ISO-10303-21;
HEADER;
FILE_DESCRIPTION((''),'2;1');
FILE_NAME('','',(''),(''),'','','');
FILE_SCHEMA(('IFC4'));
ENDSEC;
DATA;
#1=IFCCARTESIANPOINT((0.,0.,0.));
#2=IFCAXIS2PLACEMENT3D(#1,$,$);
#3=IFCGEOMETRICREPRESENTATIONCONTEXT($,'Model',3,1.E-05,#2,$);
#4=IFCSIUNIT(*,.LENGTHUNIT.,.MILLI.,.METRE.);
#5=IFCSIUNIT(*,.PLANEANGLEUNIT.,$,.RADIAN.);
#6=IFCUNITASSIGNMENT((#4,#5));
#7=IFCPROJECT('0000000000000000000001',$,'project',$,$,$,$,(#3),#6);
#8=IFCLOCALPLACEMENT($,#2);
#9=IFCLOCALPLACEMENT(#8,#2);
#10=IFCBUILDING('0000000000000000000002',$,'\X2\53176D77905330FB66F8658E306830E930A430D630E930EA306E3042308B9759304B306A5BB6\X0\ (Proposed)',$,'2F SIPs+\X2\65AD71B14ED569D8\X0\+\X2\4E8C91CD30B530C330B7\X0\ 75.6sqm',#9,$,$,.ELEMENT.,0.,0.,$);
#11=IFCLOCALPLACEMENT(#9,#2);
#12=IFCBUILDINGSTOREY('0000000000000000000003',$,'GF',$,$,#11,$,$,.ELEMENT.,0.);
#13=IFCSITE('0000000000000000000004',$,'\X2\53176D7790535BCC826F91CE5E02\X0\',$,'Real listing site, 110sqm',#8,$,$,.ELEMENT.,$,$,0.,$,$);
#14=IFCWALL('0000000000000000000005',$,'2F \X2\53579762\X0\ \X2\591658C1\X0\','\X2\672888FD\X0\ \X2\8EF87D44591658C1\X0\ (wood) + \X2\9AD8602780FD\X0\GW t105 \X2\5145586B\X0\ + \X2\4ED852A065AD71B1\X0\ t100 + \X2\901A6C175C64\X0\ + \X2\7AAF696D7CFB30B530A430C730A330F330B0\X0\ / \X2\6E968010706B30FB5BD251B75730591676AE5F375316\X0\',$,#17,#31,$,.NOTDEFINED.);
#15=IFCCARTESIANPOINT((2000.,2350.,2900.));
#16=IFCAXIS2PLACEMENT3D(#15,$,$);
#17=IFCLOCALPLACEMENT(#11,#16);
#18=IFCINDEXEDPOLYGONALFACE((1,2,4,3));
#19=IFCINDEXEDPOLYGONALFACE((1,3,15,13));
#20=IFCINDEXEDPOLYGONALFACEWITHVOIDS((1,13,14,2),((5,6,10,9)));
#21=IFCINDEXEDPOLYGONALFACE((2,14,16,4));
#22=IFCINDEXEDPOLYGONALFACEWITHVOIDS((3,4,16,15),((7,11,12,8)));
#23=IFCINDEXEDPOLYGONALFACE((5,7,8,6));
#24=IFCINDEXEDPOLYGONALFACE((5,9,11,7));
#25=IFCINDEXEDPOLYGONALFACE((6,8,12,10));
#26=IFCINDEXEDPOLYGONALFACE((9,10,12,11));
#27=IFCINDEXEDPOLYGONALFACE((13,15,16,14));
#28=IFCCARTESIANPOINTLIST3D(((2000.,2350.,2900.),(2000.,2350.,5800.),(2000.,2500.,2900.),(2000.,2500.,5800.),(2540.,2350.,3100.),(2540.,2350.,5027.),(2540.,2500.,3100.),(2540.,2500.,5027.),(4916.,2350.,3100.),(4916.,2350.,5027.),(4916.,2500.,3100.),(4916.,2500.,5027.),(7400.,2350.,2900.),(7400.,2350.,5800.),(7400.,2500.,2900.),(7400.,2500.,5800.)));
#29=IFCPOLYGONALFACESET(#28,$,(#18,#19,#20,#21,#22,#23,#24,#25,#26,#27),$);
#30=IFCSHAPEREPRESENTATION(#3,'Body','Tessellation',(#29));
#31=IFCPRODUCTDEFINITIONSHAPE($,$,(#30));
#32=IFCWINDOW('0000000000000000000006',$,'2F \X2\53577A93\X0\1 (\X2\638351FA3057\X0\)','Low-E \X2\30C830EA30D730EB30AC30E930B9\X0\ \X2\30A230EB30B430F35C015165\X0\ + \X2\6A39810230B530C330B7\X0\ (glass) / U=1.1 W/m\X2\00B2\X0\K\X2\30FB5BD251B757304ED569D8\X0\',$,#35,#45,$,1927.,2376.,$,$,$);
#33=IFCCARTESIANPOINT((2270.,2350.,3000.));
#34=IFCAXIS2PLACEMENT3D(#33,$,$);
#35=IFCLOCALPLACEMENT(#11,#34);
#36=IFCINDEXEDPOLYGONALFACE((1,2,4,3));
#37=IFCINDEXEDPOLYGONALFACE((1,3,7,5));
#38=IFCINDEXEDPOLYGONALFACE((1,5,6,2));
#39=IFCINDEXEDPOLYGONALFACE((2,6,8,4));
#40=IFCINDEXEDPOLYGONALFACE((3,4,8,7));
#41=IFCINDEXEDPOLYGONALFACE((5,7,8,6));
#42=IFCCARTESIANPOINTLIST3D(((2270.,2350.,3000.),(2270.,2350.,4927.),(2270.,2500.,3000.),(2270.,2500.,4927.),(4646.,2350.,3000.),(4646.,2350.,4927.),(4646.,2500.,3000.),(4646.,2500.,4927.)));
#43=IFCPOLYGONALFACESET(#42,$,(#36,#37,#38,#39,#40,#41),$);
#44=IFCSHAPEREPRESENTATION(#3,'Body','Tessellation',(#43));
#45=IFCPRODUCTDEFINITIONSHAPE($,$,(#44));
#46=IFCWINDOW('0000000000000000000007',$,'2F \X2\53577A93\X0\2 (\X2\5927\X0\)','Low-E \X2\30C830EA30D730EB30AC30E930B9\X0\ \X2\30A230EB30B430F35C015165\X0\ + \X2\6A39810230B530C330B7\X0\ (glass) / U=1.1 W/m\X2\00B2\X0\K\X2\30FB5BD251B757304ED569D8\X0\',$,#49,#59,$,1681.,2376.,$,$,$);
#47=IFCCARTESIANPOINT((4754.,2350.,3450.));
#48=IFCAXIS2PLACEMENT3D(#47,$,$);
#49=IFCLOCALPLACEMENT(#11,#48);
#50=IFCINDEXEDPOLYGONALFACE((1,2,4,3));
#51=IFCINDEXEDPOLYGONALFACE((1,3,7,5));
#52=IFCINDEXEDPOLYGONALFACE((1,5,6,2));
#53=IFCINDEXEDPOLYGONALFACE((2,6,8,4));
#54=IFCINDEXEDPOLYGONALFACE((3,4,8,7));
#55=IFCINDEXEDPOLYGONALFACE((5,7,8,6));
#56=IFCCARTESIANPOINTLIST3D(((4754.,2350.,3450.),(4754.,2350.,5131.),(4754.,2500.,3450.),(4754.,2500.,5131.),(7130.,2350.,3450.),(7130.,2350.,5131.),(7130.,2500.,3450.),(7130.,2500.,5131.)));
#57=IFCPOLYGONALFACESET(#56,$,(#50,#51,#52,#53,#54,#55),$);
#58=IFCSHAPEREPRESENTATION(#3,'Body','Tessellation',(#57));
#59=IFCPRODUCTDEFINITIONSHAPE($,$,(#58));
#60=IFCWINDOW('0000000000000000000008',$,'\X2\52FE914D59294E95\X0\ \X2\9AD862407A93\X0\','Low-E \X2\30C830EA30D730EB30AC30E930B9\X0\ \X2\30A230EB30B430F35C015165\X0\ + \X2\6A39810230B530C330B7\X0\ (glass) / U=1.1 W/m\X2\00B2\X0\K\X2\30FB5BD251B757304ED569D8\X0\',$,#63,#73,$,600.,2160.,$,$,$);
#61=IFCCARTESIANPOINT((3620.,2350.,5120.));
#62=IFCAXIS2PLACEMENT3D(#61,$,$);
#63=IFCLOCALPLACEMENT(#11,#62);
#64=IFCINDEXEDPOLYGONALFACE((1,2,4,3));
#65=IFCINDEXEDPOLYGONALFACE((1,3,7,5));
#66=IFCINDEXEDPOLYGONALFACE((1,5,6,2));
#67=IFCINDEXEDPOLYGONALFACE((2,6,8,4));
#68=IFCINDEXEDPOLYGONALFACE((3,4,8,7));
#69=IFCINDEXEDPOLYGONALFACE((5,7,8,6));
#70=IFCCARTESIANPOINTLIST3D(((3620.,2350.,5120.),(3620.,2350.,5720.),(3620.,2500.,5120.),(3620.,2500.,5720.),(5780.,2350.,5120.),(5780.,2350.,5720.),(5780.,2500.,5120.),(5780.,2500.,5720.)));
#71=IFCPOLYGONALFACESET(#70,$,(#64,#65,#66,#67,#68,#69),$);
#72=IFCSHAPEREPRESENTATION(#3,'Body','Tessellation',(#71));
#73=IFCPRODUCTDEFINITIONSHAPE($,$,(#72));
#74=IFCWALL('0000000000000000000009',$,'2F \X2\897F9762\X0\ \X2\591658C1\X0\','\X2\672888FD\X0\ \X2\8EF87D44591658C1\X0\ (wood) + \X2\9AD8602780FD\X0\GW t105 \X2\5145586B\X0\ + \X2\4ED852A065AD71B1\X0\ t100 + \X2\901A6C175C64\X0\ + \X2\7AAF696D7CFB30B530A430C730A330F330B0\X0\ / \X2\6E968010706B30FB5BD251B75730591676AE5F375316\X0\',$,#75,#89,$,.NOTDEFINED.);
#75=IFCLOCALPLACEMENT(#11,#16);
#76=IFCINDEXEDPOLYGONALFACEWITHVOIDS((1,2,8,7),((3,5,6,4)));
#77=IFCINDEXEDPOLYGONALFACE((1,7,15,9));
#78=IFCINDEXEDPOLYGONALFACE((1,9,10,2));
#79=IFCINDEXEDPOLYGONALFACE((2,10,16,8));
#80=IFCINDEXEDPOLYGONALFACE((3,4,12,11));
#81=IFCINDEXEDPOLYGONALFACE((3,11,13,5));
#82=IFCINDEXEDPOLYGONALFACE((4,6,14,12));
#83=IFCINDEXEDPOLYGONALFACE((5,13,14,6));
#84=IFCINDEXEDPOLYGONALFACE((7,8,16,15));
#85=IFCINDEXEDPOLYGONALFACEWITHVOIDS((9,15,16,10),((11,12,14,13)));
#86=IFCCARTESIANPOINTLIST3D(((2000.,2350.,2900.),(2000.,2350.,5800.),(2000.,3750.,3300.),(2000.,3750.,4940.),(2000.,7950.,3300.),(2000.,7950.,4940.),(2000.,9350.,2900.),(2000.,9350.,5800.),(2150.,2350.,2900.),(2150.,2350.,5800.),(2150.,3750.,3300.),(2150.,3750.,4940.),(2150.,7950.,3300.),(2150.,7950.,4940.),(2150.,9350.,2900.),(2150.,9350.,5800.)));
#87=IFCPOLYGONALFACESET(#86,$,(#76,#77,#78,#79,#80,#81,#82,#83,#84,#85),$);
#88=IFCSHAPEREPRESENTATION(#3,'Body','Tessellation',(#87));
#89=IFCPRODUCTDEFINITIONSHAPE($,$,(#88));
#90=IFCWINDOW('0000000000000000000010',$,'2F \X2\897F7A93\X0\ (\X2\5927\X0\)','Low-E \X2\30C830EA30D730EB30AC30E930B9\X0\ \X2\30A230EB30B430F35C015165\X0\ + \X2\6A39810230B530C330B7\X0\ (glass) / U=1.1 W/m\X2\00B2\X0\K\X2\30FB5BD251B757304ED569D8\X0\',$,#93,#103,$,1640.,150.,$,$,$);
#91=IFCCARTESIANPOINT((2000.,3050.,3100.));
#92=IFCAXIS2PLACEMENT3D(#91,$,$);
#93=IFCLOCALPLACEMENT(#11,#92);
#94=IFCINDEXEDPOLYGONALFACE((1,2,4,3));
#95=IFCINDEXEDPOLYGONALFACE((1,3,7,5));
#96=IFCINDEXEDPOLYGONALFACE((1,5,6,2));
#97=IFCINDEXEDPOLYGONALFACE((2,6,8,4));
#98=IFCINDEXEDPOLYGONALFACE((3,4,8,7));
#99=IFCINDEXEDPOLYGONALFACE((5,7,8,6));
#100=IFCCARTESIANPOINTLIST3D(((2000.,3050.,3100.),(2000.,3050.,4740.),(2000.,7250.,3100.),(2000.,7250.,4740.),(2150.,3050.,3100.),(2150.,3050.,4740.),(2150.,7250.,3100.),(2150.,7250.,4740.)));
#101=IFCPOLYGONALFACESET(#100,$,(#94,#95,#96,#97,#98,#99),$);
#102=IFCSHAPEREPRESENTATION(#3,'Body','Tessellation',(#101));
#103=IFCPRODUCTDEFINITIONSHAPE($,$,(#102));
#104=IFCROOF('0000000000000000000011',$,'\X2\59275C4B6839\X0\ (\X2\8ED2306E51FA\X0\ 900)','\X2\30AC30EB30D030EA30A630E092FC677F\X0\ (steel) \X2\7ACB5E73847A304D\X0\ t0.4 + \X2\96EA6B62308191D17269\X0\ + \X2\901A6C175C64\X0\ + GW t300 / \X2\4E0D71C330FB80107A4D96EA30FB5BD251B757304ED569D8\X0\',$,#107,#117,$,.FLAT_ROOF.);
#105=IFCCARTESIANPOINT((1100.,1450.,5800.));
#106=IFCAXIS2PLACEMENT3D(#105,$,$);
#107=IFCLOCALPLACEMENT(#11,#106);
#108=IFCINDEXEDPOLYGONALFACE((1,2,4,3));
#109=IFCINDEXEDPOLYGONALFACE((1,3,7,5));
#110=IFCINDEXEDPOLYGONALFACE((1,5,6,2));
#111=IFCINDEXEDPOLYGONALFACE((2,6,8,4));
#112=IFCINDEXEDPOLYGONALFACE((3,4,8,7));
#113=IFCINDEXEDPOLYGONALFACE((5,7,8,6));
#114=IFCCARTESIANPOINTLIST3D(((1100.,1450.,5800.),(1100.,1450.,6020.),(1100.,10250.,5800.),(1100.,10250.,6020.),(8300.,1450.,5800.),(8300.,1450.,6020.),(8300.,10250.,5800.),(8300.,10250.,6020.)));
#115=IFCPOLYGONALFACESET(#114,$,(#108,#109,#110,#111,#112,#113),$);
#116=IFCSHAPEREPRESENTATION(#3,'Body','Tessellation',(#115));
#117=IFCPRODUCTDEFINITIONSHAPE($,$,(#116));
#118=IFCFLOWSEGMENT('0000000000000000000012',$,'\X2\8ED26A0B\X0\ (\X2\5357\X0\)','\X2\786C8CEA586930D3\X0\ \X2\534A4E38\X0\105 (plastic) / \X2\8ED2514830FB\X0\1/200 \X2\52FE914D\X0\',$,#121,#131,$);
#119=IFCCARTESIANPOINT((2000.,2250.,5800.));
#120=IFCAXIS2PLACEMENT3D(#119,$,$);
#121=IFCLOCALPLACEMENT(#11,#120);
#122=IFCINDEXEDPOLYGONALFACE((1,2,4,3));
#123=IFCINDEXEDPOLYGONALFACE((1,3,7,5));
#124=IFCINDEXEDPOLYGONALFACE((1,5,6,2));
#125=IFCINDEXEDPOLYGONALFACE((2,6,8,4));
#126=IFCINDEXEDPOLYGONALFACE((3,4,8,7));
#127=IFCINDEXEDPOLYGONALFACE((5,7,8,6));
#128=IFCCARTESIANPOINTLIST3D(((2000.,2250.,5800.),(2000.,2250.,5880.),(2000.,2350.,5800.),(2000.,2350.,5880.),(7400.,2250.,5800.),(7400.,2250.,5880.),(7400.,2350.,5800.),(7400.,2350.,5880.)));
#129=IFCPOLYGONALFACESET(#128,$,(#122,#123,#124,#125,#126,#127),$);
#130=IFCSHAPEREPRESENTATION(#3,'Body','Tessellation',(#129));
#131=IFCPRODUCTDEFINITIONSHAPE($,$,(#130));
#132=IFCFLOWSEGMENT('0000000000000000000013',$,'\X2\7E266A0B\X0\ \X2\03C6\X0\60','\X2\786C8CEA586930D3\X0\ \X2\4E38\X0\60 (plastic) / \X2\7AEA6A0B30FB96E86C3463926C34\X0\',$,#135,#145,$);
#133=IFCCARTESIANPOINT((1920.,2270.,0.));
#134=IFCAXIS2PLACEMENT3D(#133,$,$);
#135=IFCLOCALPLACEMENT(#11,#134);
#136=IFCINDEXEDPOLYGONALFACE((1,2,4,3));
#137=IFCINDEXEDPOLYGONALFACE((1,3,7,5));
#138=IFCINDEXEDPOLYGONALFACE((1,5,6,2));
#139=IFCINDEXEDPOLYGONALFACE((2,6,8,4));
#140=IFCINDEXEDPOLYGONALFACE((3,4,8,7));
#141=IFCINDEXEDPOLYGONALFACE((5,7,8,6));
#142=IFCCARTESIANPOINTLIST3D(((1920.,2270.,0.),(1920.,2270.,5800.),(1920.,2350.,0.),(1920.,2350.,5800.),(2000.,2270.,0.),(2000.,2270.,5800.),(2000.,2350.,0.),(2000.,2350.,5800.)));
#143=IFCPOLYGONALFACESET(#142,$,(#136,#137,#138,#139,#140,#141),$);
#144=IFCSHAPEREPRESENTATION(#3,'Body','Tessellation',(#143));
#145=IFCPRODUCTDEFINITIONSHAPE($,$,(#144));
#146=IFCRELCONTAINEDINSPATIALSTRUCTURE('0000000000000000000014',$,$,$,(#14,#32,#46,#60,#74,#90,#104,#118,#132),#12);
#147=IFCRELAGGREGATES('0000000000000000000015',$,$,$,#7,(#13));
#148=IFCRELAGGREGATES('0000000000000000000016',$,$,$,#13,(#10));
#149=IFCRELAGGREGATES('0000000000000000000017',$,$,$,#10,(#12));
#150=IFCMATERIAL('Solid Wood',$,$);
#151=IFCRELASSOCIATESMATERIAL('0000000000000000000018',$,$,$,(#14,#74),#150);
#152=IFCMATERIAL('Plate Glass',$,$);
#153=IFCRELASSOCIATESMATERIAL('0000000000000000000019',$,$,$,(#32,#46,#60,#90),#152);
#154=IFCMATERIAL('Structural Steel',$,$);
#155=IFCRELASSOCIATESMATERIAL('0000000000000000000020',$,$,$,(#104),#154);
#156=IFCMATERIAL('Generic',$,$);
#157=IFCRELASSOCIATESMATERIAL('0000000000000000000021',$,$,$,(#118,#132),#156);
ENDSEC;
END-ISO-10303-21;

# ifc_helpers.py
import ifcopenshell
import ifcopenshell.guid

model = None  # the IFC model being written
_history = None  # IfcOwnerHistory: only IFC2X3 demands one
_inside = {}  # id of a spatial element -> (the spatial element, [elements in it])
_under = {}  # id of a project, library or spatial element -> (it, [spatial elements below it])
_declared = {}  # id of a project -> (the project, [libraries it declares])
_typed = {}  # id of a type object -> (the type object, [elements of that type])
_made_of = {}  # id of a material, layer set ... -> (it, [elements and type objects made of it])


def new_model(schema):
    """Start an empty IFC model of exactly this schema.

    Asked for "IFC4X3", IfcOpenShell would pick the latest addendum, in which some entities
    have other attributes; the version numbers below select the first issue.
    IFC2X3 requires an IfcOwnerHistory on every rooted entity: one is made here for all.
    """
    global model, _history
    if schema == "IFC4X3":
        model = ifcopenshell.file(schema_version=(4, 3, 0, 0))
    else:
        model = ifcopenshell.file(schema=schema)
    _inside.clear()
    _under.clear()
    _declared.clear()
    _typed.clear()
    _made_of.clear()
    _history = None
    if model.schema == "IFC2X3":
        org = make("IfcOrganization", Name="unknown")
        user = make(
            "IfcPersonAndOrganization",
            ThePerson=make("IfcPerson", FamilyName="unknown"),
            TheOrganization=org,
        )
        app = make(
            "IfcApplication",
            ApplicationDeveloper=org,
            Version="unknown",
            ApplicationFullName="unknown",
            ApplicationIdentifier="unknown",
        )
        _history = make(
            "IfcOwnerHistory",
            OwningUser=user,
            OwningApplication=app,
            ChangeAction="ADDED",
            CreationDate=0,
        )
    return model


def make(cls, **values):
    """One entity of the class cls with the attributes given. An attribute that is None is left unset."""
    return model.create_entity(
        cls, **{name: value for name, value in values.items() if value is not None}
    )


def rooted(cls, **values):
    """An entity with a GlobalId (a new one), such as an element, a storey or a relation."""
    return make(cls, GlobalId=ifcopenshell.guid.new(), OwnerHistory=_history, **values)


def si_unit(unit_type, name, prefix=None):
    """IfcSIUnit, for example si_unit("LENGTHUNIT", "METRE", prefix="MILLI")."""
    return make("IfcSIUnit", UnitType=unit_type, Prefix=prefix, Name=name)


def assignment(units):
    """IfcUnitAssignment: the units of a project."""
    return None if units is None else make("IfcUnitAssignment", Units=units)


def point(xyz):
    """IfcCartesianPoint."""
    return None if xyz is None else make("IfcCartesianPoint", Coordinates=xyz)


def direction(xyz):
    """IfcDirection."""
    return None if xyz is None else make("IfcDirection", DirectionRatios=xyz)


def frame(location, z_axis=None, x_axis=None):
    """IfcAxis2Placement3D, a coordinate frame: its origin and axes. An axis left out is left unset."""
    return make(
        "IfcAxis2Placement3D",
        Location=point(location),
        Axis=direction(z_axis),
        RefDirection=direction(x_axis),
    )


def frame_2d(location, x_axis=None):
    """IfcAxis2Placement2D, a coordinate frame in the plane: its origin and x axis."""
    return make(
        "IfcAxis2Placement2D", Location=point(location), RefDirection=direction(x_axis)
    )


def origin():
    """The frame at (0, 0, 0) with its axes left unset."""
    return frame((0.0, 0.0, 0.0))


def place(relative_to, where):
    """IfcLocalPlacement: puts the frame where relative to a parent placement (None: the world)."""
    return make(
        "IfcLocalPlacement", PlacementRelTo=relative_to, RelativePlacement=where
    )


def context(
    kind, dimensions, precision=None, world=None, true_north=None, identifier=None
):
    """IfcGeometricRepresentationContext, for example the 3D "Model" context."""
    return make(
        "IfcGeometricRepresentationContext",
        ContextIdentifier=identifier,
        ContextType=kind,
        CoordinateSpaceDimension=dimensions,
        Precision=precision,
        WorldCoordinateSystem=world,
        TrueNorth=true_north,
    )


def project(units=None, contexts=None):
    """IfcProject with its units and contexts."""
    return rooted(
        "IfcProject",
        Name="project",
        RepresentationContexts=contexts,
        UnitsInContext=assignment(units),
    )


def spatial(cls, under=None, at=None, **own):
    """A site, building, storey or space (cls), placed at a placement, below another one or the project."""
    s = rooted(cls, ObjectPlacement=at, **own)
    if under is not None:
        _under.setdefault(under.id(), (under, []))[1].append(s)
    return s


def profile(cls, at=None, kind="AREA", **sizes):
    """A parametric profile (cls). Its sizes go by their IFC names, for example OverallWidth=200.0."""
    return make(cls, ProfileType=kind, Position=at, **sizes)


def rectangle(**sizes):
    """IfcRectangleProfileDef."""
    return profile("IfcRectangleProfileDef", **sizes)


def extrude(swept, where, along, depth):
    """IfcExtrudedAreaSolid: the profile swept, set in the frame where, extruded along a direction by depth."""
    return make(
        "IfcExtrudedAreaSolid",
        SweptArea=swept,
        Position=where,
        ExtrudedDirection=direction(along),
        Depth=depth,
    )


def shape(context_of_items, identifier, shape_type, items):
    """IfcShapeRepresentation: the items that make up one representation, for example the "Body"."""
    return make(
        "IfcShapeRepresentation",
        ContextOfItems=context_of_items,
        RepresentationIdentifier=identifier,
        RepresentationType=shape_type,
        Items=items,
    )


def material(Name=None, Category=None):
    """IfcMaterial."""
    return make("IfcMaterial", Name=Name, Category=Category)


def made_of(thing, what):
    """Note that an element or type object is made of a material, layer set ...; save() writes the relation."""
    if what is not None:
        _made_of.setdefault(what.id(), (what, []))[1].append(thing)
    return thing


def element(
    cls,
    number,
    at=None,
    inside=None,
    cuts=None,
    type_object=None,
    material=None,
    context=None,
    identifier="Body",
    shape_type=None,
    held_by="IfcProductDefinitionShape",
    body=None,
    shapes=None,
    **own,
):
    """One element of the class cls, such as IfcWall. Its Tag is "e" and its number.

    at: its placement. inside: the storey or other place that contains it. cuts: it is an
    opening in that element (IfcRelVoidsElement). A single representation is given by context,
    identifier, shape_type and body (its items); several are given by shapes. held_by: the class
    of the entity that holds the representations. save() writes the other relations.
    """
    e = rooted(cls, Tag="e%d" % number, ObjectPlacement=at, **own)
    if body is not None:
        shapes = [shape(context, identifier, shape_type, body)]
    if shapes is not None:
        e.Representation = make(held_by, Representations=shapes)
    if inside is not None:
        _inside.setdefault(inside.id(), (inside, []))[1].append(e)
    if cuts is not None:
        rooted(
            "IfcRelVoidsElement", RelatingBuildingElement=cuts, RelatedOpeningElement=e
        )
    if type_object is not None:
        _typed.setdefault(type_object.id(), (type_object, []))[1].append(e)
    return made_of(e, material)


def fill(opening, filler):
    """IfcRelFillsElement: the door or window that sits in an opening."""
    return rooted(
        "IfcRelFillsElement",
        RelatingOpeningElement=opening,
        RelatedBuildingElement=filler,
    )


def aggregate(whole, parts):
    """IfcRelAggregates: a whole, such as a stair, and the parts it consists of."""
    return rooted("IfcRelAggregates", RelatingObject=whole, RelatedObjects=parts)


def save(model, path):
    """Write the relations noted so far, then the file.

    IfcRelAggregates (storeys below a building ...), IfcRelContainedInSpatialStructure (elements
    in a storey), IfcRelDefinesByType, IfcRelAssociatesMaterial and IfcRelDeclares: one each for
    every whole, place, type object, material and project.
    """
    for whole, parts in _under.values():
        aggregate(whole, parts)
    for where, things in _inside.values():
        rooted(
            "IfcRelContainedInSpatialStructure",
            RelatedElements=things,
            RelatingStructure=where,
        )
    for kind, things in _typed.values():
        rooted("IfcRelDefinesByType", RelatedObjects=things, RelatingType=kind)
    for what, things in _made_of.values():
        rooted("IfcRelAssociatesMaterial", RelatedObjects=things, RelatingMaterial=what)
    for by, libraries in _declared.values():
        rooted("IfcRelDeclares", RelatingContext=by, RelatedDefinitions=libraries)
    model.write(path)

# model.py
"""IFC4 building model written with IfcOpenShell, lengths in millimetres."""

from ifc_helpers import new_model, si_unit, frame, frame_2d, origin, place, context, project, spatial, rectangle, extrude, material, element, fill, save


model = new_model("IFC4")

# Units and contexts
model_context = context("Model", 3, precision=1e-05, world=origin())
ifc_project = project(units=[si_unit("LENGTHUNIT", "METRE", prefix="MILLI"), si_unit("PLANEANGLEUNIT", "RADIAN")], contexts=[model_context])

# Site, building, storey
site_placement = place(None, origin())
site = spatial("IfcSite", under=ifc_project, at=site_placement, Name="北海道富良野市", ObjectType="Real listing site, 110sqm", CompositionType="ELEMENT", RefElevation=0.0)
building_placement = place(site_placement, origin())
building = spatial("IfcBuilding", under=site, at=building_placement, Name="北海道・書斎とライブラリのある静かな家 (Proposed)", ObjectType="2F SIPs+断熱仕様+二重サッシ 75.6sqm", CompositionType="ELEMENT", ElevationOfRefHeight=0.0, ElevationOfTerrain=0.0)
storey_placement = place(building_placement, origin())
storey = spatial("IfcBuildingStorey", under=building, at=storey_placement, Name="GF", CompositionType="ELEMENT", Elevation=0.0)

# Shared definitions
ifc_material_1 = material(Name="Solid Wood")

# Shared definitions
ifc_material_2 = material(Name="Plate Glass")

# Wall, openings, windows
wall_1_placement = place(storey_placement, frame((2000.0, 2350.0, 2900.0)))
wall_1 = element("IfcWall", 1, at=wall_1_placement, inside=storey, material=ifc_material_1, Name="2F 南面 外壁", Description="木製 軸組外壁 (wood) + 高性能GW t105 充填 + 付加断熱 t100 + 通気層 + 窯業系サイディング / 準耐火・寒冷地外皮強化", PredefinedType="NOTDEFINED", context=model_context, shape_type="SweptSolid", body=[
    extrude(rectangle(XDim=5400.0, YDim=150.0, at=frame_2d((2700.0, 75.0))), frame((2000.0, 2350.0, 2900.0)), (0.0, 0.0, 1.0), 2900.0),
])
opening_1_placement = place(storey_placement, frame((2270.0, 2350.0, 3000.0)))
opening_1 = element("IfcOpeningElement", 2, at=opening_1_placement, cuts=wall_1, PredefinedType="NOTDEFINED", context=model_context, shape_type="SweptSolid", body=[
    extrude(rectangle(XDim=2376.0, YDim=150.0, at=frame_2d((1188.0, 75.0))), frame((2270.0, 2350.0, 3000.0)), (0.0, 0.0, 1.0), 1927.0),
])
opening_2_placement = place(storey_placement, frame((4754.0, 2350.0, 3450.0)))
opening_2 = element("IfcOpeningElement", 3, at=opening_2_placement, cuts=wall_1, PredefinedType="NOTDEFINED", context=model_context, shape_type="SweptSolid", body=[
    extrude(rectangle(XDim=2376.0, YDim=150.0, at=frame_2d((1188.0, 75.0))), frame((4754.0, 2350.0, 3450.0)), (0.0, 0.0, 1.0), 1681.0),
])
opening_3_placement = place(storey_placement, frame((3620.0, 2350.0, 5120.0)))
opening_3 = element("IfcOpeningElement", 4, at=opening_3_placement, cuts=wall_1, PredefinedType="NOTDEFINED", context=model_context, shape_type="SweptSolid", body=[
    extrude(rectangle(XDim=2160.0, YDim=150.0, at=frame_2d((1080.0, 75.0))), frame((3620.0, 2350.0, 5120.0)), (0.0, 0.0, 1.0), 600.0),
])
window_1_placement = place(storey_placement, frame((2270.0, 2350.0, 3000.0)))
window_1 = element("IfcWindow", 5, at=window_1_placement, inside=storey, material=ifc_material_2, Name="2F 南窓1 (掃出し)", Description="Low-E トリプルガラス アルゴン封入 + 樹脂サッシ (glass) / U=1.1 W/m²K・寒冷地仕様", OverallHeight=1927.0, OverallWidth=2376.0, context=model_context, shape_type="SweptSolid", body=[
    extrude(rectangle(XDim=2376.0, YDim=150.0, at=frame_2d((1188.0, 75.0))), frame((2270.0, 2350.0, 3000.0)), (0.0, 0.0, 1.0), 1927.0),
])
fill(opening_1, window_1)
window_2_placement = place(storey_placement, frame((4754.0, 2350.0, 3450.0)))
window_2 = element("IfcWindow", 6, at=window_2_placement, inside=storey, material=ifc_material_2, Name="2F 南窓2 (大)", Description="Low-E トリプルガラス アルゴン封入 + 樹脂サッシ (glass) / U=1.1 W/m²K・寒冷地仕様", OverallHeight=1681.0, OverallWidth=2376.0, context=model_context, shape_type="SweptSolid", body=[
    extrude(rectangle(XDim=2376.0, YDim=150.0, at=frame_2d((1188.0, 75.0))), frame((4754.0, 2350.0, 3450.0)), (0.0, 0.0, 1.0), 1681.0),
])
fill(opening_2, window_2)
window_3_placement = place(storey_placement, frame((3620.0, 2350.0, 5120.0)))
window_3 = element("IfcWindow", 7, at=window_3_placement, inside=storey, material=ifc_material_2, Name="勾配天井 高所窓", Description="Low-E トリプルガラス アルゴン封入 + 樹脂サッシ (glass) / U=1.1 W/m²K・寒冷地仕様", OverallHeight=600.0, OverallWidth=2160.0, context=model_context, shape_type="SweptSolid", body=[
    extrude(rectangle(XDim=2160.0, YDim=150.0, at=frame_2d((1080.0, 75.0))), frame((3620.0, 2350.0, 5120.0)), (0.0, 0.0, 1.0), 600.0),
])
fill(opening_3, window_3)

# Wall, opening, window
wall_2_placement = place(storey_placement, frame((2000.0, 2350.0, 2900.0)))
wall_2 = element("IfcWall", 8, at=wall_2_placement, inside=storey, material=ifc_material_1, Name="2F 西面 外壁", Description="木製 軸組外壁 (wood) + 高性能GW t105 充填 + 付加断熱 t100 + 通気層 + 窯業系サイディング / 準耐火・寒冷地外皮強化", PredefinedType="NOTDEFINED", context=model_context, shape_type="SweptSolid", body=[
    extrude(rectangle(XDim=150.0, YDim=7000.0, at=frame_2d((75.0, 3500.0))), frame((2000.0, 2350.0, 2900.0)), (0.0, 0.0, 1.0), 2900.0),
])
opening_4_placement = place(storey_placement, frame((2000.0, 3050.0, 3100.0)))
opening_4 = element("IfcOpeningElement", 9, at=opening_4_placement, cuts=wall_2, PredefinedType="NOTDEFINED", context=model_context, shape_type="SweptSolid", body=[
    extrude(rectangle(XDim=150.0, YDim=4200.0, at=frame_2d((75.0, 2100.0))), frame((2000.0, 3050.0, 3100.0)), (0.0, 0.0, 1.0), 1640.0),
])
window_4_placement = place(storey_placement, frame((2000.0, 3050.0, 3100.0)))
window_4 = element("IfcWindow", 10, at=window_4_placement, inside=storey, material=ifc_material_2, Name="2F 西窓 (大)", Description="Low-E トリプルガラス アルゴン封入 + 樹脂サッシ (glass) / U=1.1 W/m²K・寒冷地仕様", OverallHeight=1640.0, OverallWidth=150.0, context=model_context, shape_type="SweptSolid", body=[
    extrude(rectangle(XDim=150.0, YDim=4200.0, at=frame_2d((75.0, 2100.0))), frame((2000.0, 3050.0, 3100.0)), (0.0, 0.0, 1.0), 1640.0),
])
fill(opening_4, window_4)

# Roof
ifc_material_3 = material(Name="Structural Steel")
roof_placement = place(storey_placement, frame((1100.0, 1450.0, 5800.0)))
element("IfcRoof", 11, at=roof_placement, inside=storey, material=ifc_material_3, Name="大屋根 (軒の出 900)", Description="ガルバリウム鋼板 (steel) 立平葺き t0.4 + 雪止め金物 + 通気層 + GW t300 / 不燃・耐積雪・寒冷地仕様", PredefinedType="FLAT_ROOF", context=model_context, shape_type="SweptSolid", body=[
    extrude(rectangle(XDim=7200.0, YDim=8800.0, at=frame_2d((3600.0, 4400.0))), frame((1100.0, 1450.0, 5800.0)), (0.0, 0.0, 1.0), 220.0),
])

# Flow segments
ifc_material_4 = material(Name="Generic")
flow_segment_1_placement = place(storey_placement, frame((2000.0, 2250.0, 5800.0)))
element("IfcFlowSegment", 12, at=flow_segment_1_placement, inside=storey, material=ifc_material_4, Name="軒樋 (南)", Description="硬質塩ビ 半丸105 (plastic) / 軒先・1/200 勾配", context=model_context, shape_type="SweptSolid", body=[
    extrude(rectangle(XDim=5400.0, YDim=100.0, at=frame_2d((2700.0, 50.0))), frame((2000.0, 2250.0, 5800.0)), (0.0, 0.0, 1.0), 80.0),
])
flow_segment_2_placement = place(storey_placement, frame((1920.0, 2270.0, 0.0)))
element("IfcFlowSegment", 13, at=flow_segment_2_placement, inside=storey, material=ifc_material_4, Name="縦樋 φ60", Description="硬質塩ビ 丸60 (plastic) / 竪樋・雨水排水", context=model_context, shape_type="SweptSolid", body=[
    extrude(rectangle(XDim=80.0, YDim=80.0, at=frame_2d((40.0, 40.0))), frame((1920.0, 2270.0, 0.0)), (0.0, 0.0, 1.0), 5800.0),
])

save(model, "model.ifc")
